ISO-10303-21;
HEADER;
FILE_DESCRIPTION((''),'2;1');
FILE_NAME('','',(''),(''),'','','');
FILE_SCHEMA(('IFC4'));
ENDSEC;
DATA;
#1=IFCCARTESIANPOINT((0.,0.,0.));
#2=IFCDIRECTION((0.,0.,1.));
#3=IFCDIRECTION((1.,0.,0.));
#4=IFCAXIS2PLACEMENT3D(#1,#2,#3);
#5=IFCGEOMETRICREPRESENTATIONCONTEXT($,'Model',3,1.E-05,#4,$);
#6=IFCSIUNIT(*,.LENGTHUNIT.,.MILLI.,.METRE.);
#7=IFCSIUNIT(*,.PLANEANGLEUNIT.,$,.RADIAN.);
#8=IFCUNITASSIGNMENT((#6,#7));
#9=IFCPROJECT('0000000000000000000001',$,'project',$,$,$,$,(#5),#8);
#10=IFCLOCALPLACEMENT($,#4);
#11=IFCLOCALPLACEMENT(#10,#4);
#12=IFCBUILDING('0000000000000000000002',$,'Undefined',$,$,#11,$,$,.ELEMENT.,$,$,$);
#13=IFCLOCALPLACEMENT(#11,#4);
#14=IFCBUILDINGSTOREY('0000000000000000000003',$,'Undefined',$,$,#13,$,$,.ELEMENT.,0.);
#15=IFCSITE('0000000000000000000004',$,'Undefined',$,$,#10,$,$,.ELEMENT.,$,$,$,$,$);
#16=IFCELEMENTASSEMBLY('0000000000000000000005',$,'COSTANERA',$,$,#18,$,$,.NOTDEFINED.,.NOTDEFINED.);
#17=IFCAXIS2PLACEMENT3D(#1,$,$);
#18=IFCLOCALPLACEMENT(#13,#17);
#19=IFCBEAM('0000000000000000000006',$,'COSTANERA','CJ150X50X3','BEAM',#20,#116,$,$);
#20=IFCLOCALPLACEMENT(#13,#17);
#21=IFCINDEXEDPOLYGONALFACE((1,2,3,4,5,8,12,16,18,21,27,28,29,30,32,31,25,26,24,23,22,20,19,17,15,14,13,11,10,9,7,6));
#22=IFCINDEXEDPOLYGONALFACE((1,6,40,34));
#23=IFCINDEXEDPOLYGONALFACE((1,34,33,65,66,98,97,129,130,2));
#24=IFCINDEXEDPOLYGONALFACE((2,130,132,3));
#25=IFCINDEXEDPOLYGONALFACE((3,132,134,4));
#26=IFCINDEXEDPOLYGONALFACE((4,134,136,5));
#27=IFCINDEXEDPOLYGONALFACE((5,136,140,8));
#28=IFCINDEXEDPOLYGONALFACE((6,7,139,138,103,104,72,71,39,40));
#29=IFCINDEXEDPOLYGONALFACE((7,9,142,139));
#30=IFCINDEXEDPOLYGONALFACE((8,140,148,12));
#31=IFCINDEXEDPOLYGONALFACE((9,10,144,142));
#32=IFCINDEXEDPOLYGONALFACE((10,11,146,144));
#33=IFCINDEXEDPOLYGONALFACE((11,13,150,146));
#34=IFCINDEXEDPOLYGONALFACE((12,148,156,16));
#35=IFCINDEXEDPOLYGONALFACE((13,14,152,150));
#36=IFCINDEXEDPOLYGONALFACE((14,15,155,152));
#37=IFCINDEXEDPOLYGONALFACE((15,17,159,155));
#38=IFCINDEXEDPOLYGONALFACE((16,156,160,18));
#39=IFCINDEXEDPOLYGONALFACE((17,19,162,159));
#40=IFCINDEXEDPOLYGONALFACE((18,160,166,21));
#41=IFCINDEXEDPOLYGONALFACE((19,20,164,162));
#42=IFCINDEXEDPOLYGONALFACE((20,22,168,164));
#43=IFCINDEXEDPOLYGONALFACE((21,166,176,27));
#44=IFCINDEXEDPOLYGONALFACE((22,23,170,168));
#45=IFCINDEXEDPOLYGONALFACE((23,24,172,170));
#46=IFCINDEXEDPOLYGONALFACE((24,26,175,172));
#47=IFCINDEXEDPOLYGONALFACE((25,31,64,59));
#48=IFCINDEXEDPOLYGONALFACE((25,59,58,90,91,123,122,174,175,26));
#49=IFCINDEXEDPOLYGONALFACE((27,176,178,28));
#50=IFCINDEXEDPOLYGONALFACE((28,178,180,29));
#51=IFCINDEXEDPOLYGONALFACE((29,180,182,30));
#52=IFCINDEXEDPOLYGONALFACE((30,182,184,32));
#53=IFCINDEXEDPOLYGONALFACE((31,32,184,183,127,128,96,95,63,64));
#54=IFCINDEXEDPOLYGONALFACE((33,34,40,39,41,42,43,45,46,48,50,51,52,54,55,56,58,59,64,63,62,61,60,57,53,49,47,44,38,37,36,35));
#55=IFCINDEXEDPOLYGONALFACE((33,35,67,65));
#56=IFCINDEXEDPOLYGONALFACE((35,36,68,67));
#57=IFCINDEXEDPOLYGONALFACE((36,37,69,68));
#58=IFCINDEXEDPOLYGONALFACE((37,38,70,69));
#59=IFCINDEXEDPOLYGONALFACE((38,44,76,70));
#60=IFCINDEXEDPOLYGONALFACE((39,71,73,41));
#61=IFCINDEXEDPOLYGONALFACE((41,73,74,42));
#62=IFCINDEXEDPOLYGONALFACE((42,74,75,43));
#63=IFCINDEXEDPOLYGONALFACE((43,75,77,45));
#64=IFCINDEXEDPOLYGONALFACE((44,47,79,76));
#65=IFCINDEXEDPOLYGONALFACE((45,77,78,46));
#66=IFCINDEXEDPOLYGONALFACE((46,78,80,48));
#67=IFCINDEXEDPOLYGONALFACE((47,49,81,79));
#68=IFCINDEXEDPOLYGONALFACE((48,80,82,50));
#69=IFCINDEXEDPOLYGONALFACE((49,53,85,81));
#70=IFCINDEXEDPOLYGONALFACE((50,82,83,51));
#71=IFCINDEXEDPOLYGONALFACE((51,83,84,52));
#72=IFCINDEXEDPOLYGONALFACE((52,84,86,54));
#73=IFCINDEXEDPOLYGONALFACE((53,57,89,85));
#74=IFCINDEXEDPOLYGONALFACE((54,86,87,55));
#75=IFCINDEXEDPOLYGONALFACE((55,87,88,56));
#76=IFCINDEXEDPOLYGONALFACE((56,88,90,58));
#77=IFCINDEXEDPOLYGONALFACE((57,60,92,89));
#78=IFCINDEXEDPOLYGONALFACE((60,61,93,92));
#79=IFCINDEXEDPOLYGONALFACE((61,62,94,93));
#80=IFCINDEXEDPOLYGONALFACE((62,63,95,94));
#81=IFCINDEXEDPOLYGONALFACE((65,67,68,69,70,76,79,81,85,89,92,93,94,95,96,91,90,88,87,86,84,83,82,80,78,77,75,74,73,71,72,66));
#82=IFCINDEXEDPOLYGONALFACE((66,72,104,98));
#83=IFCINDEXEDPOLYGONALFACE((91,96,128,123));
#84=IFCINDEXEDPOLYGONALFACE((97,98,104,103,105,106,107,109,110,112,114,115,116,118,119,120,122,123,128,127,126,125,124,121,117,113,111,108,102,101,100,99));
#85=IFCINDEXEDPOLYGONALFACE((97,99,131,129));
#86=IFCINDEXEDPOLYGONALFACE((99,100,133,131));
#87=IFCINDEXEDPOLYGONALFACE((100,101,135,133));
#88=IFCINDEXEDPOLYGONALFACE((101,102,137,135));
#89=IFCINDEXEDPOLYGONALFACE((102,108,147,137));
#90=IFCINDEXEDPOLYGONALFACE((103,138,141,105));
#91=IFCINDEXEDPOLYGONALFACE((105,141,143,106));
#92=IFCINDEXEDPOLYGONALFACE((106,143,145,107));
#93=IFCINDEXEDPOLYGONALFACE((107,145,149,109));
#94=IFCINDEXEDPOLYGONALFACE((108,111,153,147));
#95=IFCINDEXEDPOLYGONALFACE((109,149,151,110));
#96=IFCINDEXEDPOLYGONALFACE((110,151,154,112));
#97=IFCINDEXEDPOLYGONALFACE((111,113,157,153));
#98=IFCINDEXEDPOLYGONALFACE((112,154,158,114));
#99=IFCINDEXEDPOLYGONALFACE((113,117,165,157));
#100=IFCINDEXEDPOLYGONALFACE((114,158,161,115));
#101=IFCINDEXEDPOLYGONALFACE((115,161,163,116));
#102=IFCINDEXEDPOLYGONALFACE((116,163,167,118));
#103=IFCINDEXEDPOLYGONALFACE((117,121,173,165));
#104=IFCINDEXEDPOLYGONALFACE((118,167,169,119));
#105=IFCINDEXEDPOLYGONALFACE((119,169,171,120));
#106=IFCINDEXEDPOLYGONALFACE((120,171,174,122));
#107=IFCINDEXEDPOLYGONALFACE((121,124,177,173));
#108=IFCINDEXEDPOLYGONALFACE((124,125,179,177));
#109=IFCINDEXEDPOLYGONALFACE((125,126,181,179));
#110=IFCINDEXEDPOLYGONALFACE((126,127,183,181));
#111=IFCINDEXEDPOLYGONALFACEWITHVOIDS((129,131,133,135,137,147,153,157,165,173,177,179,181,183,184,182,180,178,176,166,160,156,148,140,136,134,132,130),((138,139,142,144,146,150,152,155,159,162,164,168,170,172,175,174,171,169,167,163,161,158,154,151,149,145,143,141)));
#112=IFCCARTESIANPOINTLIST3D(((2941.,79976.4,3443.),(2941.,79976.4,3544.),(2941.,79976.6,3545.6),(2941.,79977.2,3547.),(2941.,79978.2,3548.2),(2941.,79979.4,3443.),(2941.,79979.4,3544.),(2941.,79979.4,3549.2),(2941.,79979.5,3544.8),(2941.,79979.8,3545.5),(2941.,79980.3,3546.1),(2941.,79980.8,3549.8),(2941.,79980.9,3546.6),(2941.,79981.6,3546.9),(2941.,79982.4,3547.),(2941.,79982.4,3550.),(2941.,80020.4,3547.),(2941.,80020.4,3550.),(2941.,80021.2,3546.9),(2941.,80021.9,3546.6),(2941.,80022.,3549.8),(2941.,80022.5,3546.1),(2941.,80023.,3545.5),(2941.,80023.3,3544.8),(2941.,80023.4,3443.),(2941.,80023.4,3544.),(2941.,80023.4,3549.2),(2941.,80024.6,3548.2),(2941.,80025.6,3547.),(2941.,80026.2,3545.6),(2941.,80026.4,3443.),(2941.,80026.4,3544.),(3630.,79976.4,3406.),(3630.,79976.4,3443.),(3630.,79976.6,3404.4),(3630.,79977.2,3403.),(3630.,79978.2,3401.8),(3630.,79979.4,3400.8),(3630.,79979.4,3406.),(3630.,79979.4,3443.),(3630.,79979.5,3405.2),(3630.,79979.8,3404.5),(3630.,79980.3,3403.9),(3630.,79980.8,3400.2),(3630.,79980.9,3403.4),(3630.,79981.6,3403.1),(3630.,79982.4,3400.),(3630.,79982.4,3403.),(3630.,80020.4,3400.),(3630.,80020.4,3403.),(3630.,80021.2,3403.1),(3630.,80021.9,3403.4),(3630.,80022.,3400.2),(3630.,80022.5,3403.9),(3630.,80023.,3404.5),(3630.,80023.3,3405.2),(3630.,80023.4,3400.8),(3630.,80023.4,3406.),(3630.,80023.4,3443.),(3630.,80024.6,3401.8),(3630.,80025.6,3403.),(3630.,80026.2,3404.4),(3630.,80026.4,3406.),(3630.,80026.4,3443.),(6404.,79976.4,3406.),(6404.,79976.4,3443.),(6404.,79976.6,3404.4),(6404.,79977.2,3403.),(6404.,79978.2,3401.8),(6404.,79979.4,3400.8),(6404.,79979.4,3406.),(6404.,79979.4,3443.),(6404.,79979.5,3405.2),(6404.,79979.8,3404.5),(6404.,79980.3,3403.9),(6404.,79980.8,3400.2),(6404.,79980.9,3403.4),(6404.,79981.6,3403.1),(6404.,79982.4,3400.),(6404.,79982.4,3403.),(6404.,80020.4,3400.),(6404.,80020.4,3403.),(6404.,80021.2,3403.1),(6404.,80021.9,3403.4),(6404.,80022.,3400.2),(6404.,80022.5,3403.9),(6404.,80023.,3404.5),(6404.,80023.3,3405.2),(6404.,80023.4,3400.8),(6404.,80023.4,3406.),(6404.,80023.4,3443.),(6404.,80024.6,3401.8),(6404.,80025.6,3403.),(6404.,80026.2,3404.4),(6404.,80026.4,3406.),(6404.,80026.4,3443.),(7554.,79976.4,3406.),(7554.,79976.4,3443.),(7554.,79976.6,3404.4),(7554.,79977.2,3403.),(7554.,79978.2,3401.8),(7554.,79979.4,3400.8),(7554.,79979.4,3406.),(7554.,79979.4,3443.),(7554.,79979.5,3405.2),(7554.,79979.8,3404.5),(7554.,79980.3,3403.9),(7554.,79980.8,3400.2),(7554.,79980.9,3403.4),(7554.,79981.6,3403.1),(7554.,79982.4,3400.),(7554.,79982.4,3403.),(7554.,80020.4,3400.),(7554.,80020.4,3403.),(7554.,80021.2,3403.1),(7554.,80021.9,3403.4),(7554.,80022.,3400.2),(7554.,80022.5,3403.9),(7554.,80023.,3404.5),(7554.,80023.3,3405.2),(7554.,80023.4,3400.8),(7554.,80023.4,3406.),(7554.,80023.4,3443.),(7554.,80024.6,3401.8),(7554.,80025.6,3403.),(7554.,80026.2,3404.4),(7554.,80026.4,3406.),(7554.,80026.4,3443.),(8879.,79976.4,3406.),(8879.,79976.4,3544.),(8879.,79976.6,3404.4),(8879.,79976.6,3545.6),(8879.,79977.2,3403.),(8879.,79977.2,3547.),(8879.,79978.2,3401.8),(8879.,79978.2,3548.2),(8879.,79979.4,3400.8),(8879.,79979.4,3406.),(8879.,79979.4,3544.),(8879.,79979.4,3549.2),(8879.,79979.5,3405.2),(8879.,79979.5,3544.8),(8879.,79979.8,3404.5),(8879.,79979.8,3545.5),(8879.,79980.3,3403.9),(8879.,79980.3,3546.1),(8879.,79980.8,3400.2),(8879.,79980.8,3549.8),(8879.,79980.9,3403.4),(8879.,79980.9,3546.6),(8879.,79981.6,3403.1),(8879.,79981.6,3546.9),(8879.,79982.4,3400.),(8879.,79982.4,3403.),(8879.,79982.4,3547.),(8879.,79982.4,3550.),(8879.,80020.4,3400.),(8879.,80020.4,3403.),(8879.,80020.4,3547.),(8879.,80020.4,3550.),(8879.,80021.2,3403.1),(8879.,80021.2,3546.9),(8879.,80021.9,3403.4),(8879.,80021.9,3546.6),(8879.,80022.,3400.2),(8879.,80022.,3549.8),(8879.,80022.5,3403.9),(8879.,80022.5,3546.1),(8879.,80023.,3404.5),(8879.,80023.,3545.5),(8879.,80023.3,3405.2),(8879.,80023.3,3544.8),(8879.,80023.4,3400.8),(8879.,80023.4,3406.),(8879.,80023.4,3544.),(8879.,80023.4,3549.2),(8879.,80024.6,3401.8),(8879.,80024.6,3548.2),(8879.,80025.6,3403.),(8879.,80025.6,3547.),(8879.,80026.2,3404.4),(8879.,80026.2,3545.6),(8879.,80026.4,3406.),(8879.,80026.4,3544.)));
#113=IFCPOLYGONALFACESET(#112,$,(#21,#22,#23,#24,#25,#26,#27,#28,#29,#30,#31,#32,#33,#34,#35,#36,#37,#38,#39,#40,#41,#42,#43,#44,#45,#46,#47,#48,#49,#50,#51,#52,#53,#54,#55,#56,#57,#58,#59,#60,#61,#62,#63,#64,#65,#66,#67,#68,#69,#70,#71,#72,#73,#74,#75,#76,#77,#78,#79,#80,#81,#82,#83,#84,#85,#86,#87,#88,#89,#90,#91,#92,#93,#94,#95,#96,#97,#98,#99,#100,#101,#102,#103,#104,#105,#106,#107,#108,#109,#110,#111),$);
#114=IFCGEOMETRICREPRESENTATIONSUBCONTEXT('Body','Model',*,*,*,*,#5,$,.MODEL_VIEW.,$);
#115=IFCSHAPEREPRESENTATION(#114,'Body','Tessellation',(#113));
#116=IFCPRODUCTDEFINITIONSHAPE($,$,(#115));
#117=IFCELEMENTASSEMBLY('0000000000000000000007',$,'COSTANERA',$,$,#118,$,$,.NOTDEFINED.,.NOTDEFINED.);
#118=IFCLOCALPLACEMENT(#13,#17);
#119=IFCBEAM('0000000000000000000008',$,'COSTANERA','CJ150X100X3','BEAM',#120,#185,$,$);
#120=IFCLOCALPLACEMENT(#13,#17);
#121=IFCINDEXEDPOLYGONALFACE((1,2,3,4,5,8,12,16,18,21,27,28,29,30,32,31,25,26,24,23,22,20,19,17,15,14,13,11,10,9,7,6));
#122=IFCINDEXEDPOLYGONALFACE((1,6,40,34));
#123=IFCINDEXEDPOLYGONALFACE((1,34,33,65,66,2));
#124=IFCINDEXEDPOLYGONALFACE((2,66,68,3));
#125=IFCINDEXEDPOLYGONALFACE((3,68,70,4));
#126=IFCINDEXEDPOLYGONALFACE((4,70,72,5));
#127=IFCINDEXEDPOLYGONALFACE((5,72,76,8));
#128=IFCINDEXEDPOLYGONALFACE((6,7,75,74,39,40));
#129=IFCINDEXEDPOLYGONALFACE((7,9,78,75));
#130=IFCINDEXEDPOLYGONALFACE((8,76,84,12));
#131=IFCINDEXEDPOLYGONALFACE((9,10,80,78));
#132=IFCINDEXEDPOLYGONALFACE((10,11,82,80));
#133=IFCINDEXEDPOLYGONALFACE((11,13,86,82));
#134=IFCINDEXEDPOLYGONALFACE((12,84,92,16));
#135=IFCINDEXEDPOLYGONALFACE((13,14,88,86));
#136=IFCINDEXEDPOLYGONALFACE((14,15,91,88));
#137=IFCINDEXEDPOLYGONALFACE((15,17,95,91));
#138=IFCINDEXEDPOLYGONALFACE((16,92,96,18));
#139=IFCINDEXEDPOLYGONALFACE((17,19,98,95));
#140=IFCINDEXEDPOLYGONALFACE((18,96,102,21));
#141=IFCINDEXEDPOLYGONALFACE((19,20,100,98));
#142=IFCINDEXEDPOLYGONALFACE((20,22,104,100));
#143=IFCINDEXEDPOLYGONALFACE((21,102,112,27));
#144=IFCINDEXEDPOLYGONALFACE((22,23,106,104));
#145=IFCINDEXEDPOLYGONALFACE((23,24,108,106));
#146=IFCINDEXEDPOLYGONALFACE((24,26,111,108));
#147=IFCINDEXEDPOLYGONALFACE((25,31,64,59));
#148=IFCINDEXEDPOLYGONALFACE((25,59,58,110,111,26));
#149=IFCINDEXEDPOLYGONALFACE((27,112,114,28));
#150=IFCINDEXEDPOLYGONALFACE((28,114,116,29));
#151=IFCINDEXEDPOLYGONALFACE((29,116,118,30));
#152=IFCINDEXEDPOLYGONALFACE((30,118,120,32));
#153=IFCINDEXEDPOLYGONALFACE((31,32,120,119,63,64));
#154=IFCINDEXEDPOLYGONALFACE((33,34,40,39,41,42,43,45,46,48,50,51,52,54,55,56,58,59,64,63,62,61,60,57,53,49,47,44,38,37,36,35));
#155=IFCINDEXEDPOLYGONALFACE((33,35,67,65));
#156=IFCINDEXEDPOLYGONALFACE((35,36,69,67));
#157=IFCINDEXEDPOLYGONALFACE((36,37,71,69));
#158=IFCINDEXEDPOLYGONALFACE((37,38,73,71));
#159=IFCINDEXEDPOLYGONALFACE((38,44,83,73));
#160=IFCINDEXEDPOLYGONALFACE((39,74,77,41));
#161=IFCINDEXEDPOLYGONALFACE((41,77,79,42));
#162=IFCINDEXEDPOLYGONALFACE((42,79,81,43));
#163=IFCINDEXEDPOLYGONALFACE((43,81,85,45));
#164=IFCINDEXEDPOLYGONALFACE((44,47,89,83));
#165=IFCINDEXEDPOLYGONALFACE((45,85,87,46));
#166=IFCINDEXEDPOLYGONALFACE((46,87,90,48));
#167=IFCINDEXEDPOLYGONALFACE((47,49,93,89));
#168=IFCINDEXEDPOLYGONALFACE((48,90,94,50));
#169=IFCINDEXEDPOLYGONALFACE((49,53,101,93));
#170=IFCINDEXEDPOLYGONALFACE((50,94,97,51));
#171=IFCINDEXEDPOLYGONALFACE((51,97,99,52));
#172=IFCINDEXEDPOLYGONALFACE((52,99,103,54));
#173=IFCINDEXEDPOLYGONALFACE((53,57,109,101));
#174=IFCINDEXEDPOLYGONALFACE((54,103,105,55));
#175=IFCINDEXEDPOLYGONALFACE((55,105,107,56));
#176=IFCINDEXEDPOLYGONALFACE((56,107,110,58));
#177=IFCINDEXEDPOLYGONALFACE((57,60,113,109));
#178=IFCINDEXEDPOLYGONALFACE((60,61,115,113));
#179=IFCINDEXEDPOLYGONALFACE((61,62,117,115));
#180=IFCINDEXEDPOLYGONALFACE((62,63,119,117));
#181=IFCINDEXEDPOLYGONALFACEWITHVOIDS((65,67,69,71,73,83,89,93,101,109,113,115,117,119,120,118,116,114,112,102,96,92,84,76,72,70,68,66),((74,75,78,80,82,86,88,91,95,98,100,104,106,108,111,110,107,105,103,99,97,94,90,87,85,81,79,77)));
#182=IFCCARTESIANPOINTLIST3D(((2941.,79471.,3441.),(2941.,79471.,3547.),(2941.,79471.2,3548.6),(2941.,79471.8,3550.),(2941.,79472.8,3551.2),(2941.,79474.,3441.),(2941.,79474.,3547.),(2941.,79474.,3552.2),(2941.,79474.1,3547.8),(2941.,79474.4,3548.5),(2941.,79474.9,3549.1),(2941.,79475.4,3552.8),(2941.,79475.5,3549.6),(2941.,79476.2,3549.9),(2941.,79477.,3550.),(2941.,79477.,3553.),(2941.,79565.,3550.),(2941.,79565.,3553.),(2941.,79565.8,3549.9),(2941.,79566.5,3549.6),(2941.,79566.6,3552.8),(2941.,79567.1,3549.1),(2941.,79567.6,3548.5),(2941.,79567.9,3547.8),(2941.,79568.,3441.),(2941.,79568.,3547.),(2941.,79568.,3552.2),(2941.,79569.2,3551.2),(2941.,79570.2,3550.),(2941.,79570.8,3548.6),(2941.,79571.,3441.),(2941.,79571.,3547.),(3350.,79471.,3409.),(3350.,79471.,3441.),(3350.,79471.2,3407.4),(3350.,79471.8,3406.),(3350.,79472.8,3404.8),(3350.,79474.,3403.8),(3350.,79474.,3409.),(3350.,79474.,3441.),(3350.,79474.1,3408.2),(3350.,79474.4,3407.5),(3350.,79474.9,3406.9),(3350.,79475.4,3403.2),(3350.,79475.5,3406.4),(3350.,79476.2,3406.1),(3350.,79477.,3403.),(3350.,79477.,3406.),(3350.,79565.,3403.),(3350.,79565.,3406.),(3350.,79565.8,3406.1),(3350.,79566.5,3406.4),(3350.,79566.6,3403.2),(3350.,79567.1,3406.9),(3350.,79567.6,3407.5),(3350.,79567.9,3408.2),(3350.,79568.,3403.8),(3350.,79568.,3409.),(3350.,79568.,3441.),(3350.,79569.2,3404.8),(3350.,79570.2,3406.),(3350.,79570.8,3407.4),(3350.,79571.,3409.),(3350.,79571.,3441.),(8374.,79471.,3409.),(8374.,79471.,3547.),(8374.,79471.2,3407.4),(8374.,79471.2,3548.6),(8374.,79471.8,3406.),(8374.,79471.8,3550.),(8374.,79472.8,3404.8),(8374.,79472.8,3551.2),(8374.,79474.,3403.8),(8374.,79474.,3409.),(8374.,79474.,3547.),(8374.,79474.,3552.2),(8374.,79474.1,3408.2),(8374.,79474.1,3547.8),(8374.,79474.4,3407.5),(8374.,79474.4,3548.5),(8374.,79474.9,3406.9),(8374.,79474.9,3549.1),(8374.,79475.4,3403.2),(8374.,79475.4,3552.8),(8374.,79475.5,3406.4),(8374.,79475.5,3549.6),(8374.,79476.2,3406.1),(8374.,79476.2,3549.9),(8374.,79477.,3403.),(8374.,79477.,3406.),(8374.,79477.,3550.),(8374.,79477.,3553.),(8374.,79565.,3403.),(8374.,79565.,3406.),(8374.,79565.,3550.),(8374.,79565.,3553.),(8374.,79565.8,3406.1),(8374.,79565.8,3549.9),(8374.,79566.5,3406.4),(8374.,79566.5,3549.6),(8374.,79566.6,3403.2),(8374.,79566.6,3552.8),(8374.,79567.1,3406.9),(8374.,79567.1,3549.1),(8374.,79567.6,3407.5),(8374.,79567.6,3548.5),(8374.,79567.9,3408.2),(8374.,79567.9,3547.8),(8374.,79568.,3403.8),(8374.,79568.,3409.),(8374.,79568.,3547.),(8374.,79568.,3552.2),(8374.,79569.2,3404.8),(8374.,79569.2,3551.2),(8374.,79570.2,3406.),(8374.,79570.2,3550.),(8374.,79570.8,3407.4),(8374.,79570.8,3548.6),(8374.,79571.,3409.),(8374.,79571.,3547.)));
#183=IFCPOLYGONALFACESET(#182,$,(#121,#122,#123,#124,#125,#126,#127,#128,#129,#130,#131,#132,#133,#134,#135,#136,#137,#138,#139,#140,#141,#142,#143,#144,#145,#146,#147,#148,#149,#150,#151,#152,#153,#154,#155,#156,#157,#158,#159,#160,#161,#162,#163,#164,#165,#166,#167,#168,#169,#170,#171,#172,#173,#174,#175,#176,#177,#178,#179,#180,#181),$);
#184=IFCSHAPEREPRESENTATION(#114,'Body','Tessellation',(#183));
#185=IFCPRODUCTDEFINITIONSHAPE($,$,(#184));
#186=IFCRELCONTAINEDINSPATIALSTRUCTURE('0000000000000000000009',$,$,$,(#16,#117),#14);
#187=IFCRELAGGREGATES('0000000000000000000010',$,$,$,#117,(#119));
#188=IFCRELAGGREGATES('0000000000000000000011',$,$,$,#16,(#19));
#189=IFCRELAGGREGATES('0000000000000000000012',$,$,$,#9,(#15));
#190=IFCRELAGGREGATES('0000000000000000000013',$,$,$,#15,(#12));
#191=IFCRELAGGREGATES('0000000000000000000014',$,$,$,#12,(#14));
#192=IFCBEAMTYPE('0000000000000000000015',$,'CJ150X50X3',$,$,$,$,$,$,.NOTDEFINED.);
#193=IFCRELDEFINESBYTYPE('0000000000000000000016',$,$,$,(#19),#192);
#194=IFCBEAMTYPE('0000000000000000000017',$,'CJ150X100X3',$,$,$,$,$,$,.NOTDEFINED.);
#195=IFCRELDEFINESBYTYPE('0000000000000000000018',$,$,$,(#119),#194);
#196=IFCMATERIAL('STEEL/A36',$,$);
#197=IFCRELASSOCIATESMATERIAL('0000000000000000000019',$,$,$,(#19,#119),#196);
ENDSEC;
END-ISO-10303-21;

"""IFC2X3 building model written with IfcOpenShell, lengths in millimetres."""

from ifc_helpers import new_model, si_unit, frame, origin_with_axes, origin_2d_with_axis, place, context, subcontext, project, spatial, polyline, hollow_rectangle, outline, extrude, boolean, material, type_object, element, aggregate, save


model = new_model("IFC2X3")

# Units and contexts
model_context = context("Model", 3, precision=1e-05, world=origin_with_axes())
body_context = subcontext(model_context, "Body", "Model", "MODEL_VIEW")
ifc_project = project(units=[si_unit("LENGTHUNIT", "METRE", prefix="MILLI"), si_unit("PLANEANGLEUNIT", "RADIAN")], contexts=[model_context])

# Site, building, storey
site_placement = place(None, origin_with_axes())
site = spatial("IfcSite", under=ifc_project, at=site_placement, Name="Undefined", CompositionType="ELEMENT")
building_placement = place(site_placement, origin_with_axes())
building = spatial("IfcBuilding", under=site, at=building_placement, Name="Undefined", CompositionType="ELEMENT")
storey_placement = place(building_placement, origin_with_axes())
storey = spatial("IfcBuildingStorey", under=building, at=storey_placement, Name="Undefined", CompositionType="ELEMENT", Elevation=0.0)

# Element assemblies, beams
assembly_1_placement = place(storey_placement, origin_with_axes())
assembly_1 = element("IfcElementAssembly", 1, at=assembly_1_placement, inside=storey, Name="COSTANERA", AssemblyPlace="NOTDEFINED", PredefinedType="NOTDEFINED")
ifc_material_1 = material(Name="STEEL/A36")
beam_type_1 = type_object("IfcBeamType", Name="CJ150X50X3", PredefinedType="NOTDEFINED")
beam_1_placement = place(assembly_1_placement, frame((2941.0, 80001.4, 3475.0), z_axis=(0.0, 0.0, 1.0), x_axis=(1.0, 0.0, 0.0)))
beam_1 = element("IfcBeam", 2, at=beam_1_placement, type_object=beam_type_1, material=ifc_material_1, Name="COSTANERA", Description="CJ150X50X3", ObjectType="BEAM", context=body_context, shape_type="CSG", body=[
    boolean("DIFFERENCE", boolean("DIFFERENCE", extrude(hollow_rectangle(XDim=50.0, YDim=150.0, WallThickness=3.0, InnerFilletRadius=3.0, OuterFilletRadius=6.0, at=origin_2d_with_axis()), frame((5938.0, 0.0, 0.0), z_axis=(-1.0, 0.0, 0.0), x_axis=(0.0, -1.0, 0.0)), (0.0, 0.0, 1.0), 5938.0), extrude(outline(polyline([(0.0, 0.0), (1150.0, 0.0), (1150.0, 48.0), (0.0, 48.0), (0.0, 0.0)])), frame((3463.0, -52.5, -32.0), z_axis=(0.0, 1.0, 0.0), x_axis=(1.0, 0.0, 0.0)), (0.0, 0.0, 1.0), 105.0)), extrude(outline(polyline([(0.0, 0.0), (876.0, 0.0), (876.0, 48.0), (0.0, 48.0), (0.0, 0.0)])), frame((-187.0, -52.5, -32.0), z_axis=(0.0, 1.0, 0.0), x_axis=(1.0, 0.0, 0.0)), (0.0, 0.0, 1.0), 105.0)),
])
assembly_2_placement = place(storey_placement, origin_with_axes())
assembly_2 = element("IfcElementAssembly", 3, at=assembly_2_placement, inside=storey, Name="COSTANERA", AssemblyPlace="NOTDEFINED", PredefinedType="NOTDEFINED")
beam_type_2 = type_object("IfcBeamType", Name="CJ150X100X3", PredefinedType="NOTDEFINED")
beam_2_placement = place(assembly_2_placement, frame((2941.0, 79521.0, 3478.0), z_axis=(0.0, 0.0, 1.0), x_axis=(1.0, 0.0, 0.0)))
beam_2 = element("IfcBeam", 4, at=beam_2_placement, type_object=beam_type_2, material=ifc_material_1, Name="COSTANERA", Description="CJ150X100X3", ObjectType="BEAM", context=body_context, shape_type="CSG", body=[
    boolean("DIFFERENCE", extrude(hollow_rectangle(XDim=100.0, YDim=150.0, WallThickness=3.0, InnerFilletRadius=3.0, OuterFilletRadius=6.0, at=origin_2d_with_axis()), frame((5433.0, 0.0, 0.0), z_axis=(-1.0, 0.0, 0.0), x_axis=(0.0, -1.0, 0.0)), (0.0, 0.0, 1.0), 5433.0), extrude(outline(polyline([(0.0, 0.0), (596.0, 0.0), (596.0, 43.0), (0.0, 43.0), (0.0, 0.0)])), frame((-187.0, -52.5, -37.0), z_axis=(0.0, 1.0, 0.0), x_axis=(1.0, 0.0, 0.0)), (0.0, 0.0, 1.0), 105.0)),
])

aggregate(assembly_2, [beam_2])

aggregate(assembly_1, [beam_1])

save(model, "model.ifc")
